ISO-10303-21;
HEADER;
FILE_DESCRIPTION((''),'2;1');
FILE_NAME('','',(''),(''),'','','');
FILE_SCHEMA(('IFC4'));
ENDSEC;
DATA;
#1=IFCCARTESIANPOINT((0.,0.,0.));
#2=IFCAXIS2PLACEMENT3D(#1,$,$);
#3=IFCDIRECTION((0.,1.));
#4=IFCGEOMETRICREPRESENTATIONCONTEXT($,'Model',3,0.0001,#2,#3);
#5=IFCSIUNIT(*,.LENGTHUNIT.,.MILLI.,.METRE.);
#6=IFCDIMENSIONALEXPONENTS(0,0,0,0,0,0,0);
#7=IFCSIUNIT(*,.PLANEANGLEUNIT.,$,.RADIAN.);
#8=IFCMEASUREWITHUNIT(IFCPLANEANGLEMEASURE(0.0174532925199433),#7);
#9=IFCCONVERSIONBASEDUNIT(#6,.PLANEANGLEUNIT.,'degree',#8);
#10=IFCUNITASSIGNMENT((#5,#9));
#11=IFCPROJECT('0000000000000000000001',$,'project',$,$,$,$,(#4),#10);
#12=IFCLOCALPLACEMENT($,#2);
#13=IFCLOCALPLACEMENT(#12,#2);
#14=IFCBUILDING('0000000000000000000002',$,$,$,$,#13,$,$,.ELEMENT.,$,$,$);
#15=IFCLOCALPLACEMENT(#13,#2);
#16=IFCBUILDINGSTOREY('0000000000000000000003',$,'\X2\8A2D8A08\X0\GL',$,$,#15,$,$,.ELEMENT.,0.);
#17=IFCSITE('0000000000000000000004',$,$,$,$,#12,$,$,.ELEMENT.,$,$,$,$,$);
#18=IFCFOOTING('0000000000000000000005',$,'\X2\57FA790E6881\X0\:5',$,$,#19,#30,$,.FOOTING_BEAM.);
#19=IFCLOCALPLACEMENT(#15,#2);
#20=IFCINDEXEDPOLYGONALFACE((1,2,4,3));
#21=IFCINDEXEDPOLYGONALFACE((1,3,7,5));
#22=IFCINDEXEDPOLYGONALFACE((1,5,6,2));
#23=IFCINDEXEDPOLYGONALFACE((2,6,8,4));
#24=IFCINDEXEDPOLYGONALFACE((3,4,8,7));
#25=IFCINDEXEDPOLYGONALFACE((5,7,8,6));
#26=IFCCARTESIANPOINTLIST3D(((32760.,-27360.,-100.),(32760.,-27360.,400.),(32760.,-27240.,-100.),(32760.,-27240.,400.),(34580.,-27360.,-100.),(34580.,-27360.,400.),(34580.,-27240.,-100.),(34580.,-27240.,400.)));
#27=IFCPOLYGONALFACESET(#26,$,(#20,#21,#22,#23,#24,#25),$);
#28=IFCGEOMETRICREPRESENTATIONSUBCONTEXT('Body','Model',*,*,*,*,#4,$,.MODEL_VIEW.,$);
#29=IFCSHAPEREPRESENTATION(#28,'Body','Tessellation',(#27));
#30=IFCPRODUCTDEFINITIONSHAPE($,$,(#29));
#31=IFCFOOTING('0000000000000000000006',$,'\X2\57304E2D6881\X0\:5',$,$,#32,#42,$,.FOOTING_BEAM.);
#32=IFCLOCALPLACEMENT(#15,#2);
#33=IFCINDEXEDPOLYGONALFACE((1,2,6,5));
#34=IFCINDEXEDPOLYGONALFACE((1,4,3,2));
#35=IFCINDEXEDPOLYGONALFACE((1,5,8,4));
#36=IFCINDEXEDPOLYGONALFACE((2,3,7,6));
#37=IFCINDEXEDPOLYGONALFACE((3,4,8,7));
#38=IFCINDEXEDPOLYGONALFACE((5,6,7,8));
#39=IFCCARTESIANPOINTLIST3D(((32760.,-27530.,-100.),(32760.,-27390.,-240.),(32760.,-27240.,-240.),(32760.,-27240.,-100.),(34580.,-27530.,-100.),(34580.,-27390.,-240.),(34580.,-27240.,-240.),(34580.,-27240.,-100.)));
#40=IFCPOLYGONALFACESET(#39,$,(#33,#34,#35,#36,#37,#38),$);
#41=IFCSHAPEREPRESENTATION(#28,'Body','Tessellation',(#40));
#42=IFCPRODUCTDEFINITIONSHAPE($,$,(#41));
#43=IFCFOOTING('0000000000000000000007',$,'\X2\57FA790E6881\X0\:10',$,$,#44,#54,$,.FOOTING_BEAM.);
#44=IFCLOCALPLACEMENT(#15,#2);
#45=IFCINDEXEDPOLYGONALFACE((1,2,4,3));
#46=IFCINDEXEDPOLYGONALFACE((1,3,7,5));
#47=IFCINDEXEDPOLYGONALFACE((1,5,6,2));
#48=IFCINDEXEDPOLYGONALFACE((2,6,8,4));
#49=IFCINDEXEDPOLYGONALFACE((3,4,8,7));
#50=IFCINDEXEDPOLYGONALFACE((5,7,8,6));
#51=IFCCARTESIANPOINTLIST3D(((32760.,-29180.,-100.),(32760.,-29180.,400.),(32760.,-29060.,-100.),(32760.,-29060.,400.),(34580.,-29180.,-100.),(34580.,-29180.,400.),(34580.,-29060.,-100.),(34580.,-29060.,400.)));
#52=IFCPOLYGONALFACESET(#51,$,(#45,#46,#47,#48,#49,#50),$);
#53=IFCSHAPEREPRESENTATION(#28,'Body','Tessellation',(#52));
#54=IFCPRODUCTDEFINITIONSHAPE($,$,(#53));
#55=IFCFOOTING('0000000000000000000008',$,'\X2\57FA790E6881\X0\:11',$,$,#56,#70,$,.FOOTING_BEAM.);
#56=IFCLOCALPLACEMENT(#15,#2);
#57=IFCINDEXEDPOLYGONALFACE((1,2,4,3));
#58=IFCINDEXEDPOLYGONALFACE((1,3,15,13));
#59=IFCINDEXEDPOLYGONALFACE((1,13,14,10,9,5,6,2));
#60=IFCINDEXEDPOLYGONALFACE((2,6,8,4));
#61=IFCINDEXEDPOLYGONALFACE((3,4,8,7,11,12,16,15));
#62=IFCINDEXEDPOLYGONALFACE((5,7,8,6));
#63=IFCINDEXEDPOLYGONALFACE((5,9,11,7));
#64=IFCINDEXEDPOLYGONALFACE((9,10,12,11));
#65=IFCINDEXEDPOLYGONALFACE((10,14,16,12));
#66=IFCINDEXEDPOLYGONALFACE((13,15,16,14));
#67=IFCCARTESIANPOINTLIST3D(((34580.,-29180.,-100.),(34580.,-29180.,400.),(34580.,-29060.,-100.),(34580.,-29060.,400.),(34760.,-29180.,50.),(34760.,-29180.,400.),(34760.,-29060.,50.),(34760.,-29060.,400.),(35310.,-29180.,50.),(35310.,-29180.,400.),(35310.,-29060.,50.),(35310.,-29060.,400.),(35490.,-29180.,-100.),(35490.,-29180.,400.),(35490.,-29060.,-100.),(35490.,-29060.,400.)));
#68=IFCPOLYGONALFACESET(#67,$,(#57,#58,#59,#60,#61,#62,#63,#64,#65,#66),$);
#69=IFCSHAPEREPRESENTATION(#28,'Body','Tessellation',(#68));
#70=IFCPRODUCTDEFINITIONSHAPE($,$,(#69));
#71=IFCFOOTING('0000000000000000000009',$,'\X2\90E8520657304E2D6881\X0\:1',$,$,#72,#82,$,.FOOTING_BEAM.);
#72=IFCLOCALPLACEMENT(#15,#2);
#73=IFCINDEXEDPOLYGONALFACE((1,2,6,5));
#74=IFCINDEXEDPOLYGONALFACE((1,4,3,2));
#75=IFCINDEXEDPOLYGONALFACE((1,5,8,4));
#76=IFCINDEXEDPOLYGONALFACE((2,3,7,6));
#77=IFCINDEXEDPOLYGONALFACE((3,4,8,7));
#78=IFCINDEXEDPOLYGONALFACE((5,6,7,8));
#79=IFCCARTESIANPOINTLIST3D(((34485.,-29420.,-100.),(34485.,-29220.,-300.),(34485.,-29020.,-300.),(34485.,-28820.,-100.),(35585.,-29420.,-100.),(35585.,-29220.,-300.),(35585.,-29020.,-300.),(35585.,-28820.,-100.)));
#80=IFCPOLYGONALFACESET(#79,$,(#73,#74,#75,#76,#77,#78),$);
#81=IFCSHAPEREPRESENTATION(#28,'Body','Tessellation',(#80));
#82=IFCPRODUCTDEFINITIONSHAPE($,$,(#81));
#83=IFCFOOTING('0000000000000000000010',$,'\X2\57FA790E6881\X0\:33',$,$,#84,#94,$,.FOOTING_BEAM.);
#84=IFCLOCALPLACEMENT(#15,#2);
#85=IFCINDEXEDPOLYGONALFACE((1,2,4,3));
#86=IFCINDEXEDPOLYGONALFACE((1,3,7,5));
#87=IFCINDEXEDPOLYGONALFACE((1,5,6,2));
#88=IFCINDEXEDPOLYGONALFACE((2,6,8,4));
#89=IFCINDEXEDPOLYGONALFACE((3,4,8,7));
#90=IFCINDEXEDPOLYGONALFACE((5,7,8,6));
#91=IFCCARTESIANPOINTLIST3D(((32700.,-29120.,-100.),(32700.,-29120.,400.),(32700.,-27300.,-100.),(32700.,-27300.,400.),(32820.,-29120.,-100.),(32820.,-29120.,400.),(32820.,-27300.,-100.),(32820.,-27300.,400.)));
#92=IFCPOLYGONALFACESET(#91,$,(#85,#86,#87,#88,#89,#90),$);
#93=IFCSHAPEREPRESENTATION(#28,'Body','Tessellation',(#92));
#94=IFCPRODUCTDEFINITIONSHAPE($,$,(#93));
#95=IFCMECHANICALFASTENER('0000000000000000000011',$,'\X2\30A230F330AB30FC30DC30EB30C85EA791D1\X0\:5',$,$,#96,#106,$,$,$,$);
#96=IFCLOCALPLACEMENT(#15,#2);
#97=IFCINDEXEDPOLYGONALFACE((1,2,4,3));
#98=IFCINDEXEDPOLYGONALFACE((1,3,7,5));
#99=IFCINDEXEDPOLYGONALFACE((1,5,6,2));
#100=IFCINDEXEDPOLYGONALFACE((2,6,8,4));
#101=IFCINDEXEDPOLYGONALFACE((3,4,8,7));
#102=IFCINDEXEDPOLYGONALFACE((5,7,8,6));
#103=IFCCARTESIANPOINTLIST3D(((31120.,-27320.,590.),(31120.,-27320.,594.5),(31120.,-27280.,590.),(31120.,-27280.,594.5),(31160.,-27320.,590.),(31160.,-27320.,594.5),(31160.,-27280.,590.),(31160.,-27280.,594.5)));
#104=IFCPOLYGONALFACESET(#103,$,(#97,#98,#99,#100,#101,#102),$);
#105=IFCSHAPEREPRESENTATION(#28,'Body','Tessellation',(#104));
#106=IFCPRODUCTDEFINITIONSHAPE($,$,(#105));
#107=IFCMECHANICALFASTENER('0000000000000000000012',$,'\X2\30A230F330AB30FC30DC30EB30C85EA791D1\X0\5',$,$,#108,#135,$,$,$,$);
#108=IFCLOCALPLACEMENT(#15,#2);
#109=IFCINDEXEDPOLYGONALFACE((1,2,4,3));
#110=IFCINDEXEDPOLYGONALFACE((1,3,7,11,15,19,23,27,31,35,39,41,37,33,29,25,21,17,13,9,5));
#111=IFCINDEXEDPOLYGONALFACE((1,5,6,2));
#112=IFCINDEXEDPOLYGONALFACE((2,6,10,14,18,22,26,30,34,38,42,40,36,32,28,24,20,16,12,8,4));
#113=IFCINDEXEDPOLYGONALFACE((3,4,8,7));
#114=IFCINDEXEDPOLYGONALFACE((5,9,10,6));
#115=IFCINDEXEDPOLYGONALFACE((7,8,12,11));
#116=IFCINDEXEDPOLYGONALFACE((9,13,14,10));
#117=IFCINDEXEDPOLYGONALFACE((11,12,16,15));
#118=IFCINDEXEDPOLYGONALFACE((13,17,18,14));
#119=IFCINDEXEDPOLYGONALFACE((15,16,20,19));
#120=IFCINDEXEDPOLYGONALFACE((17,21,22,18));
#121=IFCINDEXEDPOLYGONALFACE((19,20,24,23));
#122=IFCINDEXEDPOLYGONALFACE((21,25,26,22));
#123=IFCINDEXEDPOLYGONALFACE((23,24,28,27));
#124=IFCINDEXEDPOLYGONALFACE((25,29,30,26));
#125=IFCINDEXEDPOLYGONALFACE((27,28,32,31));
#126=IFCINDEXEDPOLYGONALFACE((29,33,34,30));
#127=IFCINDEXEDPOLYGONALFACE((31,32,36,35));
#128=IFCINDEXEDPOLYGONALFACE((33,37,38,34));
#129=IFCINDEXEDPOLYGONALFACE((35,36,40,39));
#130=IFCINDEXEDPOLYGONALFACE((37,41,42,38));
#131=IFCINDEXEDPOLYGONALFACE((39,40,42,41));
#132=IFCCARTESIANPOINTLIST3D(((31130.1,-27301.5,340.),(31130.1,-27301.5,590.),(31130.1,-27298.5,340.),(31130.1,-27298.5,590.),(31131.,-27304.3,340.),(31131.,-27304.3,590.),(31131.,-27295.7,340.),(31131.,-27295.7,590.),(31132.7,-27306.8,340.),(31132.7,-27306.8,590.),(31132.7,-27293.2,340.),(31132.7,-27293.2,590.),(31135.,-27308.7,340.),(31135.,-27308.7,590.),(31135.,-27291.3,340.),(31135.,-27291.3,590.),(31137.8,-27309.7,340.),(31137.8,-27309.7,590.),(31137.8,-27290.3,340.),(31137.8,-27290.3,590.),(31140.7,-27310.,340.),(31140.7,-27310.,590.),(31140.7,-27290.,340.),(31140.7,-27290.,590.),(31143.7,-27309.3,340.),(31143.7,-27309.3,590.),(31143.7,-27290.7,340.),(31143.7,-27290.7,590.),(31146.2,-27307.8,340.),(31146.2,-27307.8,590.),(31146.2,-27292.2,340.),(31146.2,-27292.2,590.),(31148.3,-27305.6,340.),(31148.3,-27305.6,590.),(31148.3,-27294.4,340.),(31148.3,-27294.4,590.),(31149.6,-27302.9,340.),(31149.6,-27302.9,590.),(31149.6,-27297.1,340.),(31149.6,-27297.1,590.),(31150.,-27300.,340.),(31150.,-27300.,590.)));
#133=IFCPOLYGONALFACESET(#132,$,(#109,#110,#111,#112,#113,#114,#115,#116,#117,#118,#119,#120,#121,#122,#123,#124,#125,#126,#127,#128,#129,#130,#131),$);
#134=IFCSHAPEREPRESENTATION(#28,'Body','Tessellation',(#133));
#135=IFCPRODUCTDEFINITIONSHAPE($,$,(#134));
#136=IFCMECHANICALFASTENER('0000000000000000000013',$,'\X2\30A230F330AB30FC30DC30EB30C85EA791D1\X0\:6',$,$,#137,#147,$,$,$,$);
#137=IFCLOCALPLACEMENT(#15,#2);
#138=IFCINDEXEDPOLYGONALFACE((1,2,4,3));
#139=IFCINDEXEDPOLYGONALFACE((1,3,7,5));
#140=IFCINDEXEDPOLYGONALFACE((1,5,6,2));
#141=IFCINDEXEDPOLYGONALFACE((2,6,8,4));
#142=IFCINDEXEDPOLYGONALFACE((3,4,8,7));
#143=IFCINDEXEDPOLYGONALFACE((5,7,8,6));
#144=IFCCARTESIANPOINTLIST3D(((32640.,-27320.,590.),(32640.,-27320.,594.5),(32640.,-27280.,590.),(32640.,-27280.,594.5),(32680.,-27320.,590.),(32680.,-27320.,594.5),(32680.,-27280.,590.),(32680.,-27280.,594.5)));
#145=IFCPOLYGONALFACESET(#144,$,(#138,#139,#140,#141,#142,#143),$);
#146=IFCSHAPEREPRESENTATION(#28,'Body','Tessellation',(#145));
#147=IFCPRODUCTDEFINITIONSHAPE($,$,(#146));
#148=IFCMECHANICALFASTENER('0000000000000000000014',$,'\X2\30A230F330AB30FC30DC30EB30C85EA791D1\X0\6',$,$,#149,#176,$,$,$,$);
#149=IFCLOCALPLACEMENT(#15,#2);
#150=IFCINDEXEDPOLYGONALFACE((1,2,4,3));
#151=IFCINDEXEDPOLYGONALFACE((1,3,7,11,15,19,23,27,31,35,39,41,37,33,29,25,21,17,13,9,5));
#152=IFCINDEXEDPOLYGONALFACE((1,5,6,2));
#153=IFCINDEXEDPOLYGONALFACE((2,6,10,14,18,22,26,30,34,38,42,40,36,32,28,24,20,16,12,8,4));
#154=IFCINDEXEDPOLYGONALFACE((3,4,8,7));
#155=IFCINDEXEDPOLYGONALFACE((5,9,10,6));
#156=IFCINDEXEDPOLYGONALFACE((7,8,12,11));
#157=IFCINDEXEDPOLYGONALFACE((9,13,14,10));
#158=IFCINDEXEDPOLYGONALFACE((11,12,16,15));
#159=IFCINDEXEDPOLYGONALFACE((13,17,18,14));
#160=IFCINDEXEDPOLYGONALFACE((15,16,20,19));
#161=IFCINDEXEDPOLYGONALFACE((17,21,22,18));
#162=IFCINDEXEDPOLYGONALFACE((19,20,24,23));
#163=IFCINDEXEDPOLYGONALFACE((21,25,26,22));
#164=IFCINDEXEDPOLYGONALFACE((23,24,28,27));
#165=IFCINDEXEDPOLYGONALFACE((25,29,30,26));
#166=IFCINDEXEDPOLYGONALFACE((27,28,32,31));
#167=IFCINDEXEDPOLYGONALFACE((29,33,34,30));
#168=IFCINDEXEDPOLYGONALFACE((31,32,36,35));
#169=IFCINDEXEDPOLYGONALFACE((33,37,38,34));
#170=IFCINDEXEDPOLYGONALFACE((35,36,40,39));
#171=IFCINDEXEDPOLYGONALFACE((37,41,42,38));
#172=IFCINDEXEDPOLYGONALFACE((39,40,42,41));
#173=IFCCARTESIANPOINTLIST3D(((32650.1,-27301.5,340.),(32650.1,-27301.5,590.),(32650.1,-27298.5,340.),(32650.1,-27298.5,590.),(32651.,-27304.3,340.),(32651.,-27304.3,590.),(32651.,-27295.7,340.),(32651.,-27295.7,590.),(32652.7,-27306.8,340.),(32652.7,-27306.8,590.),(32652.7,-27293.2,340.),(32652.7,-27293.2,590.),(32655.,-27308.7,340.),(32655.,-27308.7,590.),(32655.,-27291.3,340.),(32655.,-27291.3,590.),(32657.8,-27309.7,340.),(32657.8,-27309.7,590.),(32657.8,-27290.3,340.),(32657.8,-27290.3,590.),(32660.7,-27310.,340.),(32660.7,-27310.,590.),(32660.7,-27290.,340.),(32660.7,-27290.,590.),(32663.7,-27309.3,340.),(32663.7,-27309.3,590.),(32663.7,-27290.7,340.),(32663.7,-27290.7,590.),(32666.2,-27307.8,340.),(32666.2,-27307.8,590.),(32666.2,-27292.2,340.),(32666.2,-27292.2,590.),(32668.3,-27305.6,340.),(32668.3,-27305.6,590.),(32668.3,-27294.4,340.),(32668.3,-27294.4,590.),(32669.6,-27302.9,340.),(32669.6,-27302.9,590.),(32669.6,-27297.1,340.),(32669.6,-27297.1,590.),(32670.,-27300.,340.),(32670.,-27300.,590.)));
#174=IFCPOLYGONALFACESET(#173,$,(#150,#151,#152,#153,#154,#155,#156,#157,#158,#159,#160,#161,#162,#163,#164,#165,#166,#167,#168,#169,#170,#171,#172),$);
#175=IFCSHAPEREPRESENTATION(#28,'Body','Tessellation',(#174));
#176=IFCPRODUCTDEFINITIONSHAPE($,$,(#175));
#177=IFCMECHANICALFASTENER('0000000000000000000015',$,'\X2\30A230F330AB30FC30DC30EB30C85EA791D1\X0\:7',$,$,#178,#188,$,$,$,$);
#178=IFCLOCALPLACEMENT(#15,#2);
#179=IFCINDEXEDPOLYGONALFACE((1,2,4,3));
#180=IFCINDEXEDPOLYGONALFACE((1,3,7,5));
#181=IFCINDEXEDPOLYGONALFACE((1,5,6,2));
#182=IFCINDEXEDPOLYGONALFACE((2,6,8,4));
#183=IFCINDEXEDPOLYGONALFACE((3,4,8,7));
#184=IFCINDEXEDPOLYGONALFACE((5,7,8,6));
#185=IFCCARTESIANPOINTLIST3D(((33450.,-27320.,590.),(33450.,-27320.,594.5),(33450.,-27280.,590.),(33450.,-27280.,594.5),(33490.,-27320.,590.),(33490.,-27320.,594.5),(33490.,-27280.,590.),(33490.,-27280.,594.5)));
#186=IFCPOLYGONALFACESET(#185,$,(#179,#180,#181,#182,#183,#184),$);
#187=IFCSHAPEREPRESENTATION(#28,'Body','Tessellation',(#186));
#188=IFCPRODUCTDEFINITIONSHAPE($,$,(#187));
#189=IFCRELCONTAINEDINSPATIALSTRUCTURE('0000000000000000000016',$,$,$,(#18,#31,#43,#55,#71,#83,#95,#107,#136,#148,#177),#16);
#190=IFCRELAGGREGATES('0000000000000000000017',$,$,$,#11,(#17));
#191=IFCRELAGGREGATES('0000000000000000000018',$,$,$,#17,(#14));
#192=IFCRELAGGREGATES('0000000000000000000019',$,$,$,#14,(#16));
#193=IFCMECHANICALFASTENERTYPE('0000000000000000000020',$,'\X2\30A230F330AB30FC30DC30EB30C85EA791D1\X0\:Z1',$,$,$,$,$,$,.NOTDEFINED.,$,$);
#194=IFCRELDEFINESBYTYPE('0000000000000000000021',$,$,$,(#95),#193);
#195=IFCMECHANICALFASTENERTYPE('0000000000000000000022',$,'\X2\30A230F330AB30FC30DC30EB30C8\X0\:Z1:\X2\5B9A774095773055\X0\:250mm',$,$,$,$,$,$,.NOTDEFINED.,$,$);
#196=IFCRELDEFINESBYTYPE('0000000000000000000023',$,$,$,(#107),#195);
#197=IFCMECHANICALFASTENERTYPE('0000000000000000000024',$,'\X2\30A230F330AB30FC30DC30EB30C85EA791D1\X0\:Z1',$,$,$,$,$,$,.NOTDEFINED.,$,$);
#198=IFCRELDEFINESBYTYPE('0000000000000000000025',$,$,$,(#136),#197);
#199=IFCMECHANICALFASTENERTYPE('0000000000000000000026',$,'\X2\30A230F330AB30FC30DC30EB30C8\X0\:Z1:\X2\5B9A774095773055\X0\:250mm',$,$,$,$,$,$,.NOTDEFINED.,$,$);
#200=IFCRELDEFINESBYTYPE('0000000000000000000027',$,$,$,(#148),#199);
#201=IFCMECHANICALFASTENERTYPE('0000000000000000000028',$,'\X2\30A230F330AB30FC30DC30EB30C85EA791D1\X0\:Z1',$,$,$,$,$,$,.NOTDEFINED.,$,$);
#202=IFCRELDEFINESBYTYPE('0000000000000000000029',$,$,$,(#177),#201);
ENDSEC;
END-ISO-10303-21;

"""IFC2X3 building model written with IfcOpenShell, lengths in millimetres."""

from ifc_helpers import new_model, entity, si_unit, converted_unit, direction, frame, origin, origin_with_axes, origin_2d, place, context, subcontext, project, spatial, polyline, rectangle, circle, outline, extrude, boolean, type_object, element, save


model = new_model("IFC2X3")

# Units and contexts
model_context = context("Model", 3, precision=0.0001, world=origin(), true_north=direction((0.0, 1.0)))
body_context = subcontext(model_context, "Body", "Model", "MODEL_VIEW")
ifc_project = project(units=[si_unit("LENGTHUNIT", "METRE", prefix="MILLI"), converted_unit("PLANEANGLEUNIT", "degree", entity("IfcPlaneAngleMeasure", 0.0174532925199433), si_unit("PLANEANGLEUNIT", "RADIAN"), dimensions=[0, 0, 0, 0, 0, 0, 0])], contexts=[model_context])

# Site, building, storey
site_placement = place(None, origin())
site = spatial("IfcSite", under=ifc_project, at=site_placement, CompositionType="ELEMENT")
building_placement = place(site_placement, origin())
building = spatial("IfcBuilding", under=site, at=building_placement, CompositionType="ELEMENT")
storey_placement = place(building_placement, origin())
storey = spatial("IfcBuildingStorey", under=building, at=storey_placement, Name="設計GL", CompositionType="ELEMENT", Elevation=0.0)

# Footings
footing_1_placement = place(storey_placement, frame((32760.0, -27300.0, 150.0), z_axis=(1.0, 0.0, 0.0), x_axis=(0.0, 1.0, 0.0)))
element("IfcFooting", 1, at=footing_1_placement, inside=storey, Name="基礎梁:5", PredefinedType="FOOTING_BEAM", context=body_context, shape_type="SolidModel", body=[
    extrude(rectangle(XDim=120.0, YDim=500.0, at=origin_2d()), origin_with_axes(), (0.0, 0.0, 1.0), 1820.0),
])
footing_2_placement = place(storey_placement, frame((32760.0, -27240.0, -240.0), z_axis=(1.0, 0.0, 0.0), x_axis=(0.0, 1.0, 0.0)))
element("IfcFooting", 2, at=footing_2_placement, inside=storey, Name="地中梁:5", PredefinedType="FOOTING_BEAM", context=body_context, shape_type="SweptSolid", body=[
    extrude(outline(polyline([(0.0, 0.0, 0.0), (-150.0, 0.0, 0.0), (-290.0, 140.0, 0.0), (0.0, 140.0, 0.0), (0.0, 0.0, 0.0)])), origin_with_axes(), (0.0, 0.0, 1.0), 1820.0),
])
footing_3_placement = place(storey_placement, frame((32760.0, -29120.0, 150.0), z_axis=(1.0, 0.0, 0.0), x_axis=(0.0, 1.0, 0.0)))
element("IfcFooting", 3, at=footing_3_placement, inside=storey, Name="基礎梁:10", PredefinedType="FOOTING_BEAM", context=body_context, shape_type="SolidModel", body=[
    extrude(rectangle(XDim=120.0, YDim=500.0, at=origin_2d()), origin_with_axes(), (0.0, 0.0, 1.0), 1820.0),
])
footing_4_placement = place(storey_placement, frame((34580.0, -29120.0, 150.0), z_axis=(1.0, 0.0, 0.0), x_axis=(0.0, 1.0, 0.0)))
element("IfcFooting", 4, at=footing_4_placement, inside=storey, Name="基礎梁:11", PredefinedType="FOOTING_BEAM", context=body_context, shape_type="CSG", body=[
    boolean("DIFFERENCE", extrude(rectangle(XDim=120.0, YDim=500.0, at=origin_2d()), origin_with_axes(), (0.0, 0.0, 1.0), 910.0), extrude(rectangle(XDim=124.0, YDim=350.0, at=origin_2d()), frame((0.0, 75.0, 180.0), z_axis=(0.0, 0.0, 1.0), x_axis=(1.0, 0.0, 0.0)), (0.0, 0.0, 1.0), 550.0)),
])
footing_5_placement = place(storey_placement, frame((34485.0, -29120.0, -300.0), z_axis=(1.0, 0.0, 0.0), x_axis=(0.0, 1.0, 0.0)))
element("IfcFooting", 5, at=footing_5_placement, inside=storey, Name="部分地中梁:1", PredefinedType="FOOTING_BEAM", context=body_context, shape_type="SweptSolid", body=[
    extrude(outline(polyline([(-100.0, 0.0, 0.0), (100.0, 0.0, 0.0), (300.0, 200.0, 0.0), (-300.0, 200.0, 0.0), (-100.0, 0.0, 0.0)])), origin_with_axes(), (0.0, 0.0, 1.0), 1100.0),
])
footing_6_placement = place(storey_placement, frame((32760.0, -27300.0, 150.0), z_axis=(0.0, -1.0, 0.0), x_axis=(1.0, 0.0, 0.0)))
element("IfcFooting", 6, at=footing_6_placement, inside=storey, Name="基礎梁:33", PredefinedType="FOOTING_BEAM", context=body_context, shape_type="SolidModel", body=[
    extrude(rectangle(XDim=120.0, YDim=500.0, at=origin_2d()), origin_with_axes(), (0.0, 0.0, 1.0), 1820.0),
])

# Mechanical fasteners
mechanical_fastener_type_1 = type_object("IfcMechanicalFastenerType", Name="アンカーボルト座金:Z1")
mechanical_fastener_1_placement = place(storey_placement, frame((31140.0, -27300.0, 590.0)))
element("IfcMechanicalFastener", 7, at=mechanical_fastener_1_placement, inside=storey, type_object=mechanical_fastener_type_1, Name="アンカーボルト座金:5", context=body_context, shape_type="SweptSolid", body=[
    extrude(rectangle(XDim=40.0, YDim=40.0, at=origin_2d()), origin_with_axes(), (0.0, 0.0, 1.0), 4.5),
])
mechanical_fastener_type_2 = type_object("IfcMechanicalFastenerType", Name="アンカーボルト:Z1:定着長さ:250mm")
mechanical_fastener_2_placement = place(storey_placement, frame((31140.0, -27300.0, 340.0)))
element("IfcMechanicalFastener", 8, at=mechanical_fastener_2_placement, inside=storey, type_object=mechanical_fastener_type_2, Name="アンカーボルト座金5", context=body_context, shape_type="SweptSolid", body=[
    extrude(circle(Radius=10.0, at=origin_2d()), origin_with_axes(), (0.0, 0.0, 1.0), 250.0),
])
mechanical_fastener_type_3 = type_object("IfcMechanicalFastenerType", Name="アンカーボルト座金:Z1")
mechanical_fastener_3_placement = place(storey_placement, frame((32660.0, -27300.0, 590.0)))
element("IfcMechanicalFastener", 9, at=mechanical_fastener_3_placement, inside=storey, type_object=mechanical_fastener_type_3, Name="アンカーボルト座金:6", context=body_context, shape_type="SweptSolid", body=[
    extrude(rectangle(XDim=40.0, YDim=40.0, at=origin_2d()), origin_with_axes(), (0.0, 0.0, 1.0), 4.5),
])
mechanical_fastener_type_4 = type_object("IfcMechanicalFastenerType", Name="アンカーボルト:Z1:定着長さ:250mm")
mechanical_fastener_4_placement = place(storey_placement, frame((32660.0, -27300.0, 340.0)))
element("IfcMechanicalFastener", 10, at=mechanical_fastener_4_placement, inside=storey, type_object=mechanical_fastener_type_4, Name="アンカーボルト座金6", context=body_context, shape_type="SweptSolid", body=[
    extrude(circle(Radius=10.0, at=origin_2d()), origin_with_axes(), (0.0, 0.0, 1.0), 250.0),
])
mechanical_fastener_type_5 = type_object("IfcMechanicalFastenerType", Name="アンカーボルト座金:Z1")
mechanical_fastener_5_placement = place(storey_placement, frame((33470.0, -27300.0, 590.0)))
element("IfcMechanicalFastener", 11, at=mechanical_fastener_5_placement, inside=storey, type_object=mechanical_fastener_type_5, Name="アンカーボルト座金:7", context=body_context, shape_type="SweptSolid", body=[
    extrude(rectangle(XDim=40.0, YDim=40.0, at=origin_2d()), origin_with_axes(), (0.0, 0.0, 1.0), 4.5),
])

save(model, "model.ifc")
